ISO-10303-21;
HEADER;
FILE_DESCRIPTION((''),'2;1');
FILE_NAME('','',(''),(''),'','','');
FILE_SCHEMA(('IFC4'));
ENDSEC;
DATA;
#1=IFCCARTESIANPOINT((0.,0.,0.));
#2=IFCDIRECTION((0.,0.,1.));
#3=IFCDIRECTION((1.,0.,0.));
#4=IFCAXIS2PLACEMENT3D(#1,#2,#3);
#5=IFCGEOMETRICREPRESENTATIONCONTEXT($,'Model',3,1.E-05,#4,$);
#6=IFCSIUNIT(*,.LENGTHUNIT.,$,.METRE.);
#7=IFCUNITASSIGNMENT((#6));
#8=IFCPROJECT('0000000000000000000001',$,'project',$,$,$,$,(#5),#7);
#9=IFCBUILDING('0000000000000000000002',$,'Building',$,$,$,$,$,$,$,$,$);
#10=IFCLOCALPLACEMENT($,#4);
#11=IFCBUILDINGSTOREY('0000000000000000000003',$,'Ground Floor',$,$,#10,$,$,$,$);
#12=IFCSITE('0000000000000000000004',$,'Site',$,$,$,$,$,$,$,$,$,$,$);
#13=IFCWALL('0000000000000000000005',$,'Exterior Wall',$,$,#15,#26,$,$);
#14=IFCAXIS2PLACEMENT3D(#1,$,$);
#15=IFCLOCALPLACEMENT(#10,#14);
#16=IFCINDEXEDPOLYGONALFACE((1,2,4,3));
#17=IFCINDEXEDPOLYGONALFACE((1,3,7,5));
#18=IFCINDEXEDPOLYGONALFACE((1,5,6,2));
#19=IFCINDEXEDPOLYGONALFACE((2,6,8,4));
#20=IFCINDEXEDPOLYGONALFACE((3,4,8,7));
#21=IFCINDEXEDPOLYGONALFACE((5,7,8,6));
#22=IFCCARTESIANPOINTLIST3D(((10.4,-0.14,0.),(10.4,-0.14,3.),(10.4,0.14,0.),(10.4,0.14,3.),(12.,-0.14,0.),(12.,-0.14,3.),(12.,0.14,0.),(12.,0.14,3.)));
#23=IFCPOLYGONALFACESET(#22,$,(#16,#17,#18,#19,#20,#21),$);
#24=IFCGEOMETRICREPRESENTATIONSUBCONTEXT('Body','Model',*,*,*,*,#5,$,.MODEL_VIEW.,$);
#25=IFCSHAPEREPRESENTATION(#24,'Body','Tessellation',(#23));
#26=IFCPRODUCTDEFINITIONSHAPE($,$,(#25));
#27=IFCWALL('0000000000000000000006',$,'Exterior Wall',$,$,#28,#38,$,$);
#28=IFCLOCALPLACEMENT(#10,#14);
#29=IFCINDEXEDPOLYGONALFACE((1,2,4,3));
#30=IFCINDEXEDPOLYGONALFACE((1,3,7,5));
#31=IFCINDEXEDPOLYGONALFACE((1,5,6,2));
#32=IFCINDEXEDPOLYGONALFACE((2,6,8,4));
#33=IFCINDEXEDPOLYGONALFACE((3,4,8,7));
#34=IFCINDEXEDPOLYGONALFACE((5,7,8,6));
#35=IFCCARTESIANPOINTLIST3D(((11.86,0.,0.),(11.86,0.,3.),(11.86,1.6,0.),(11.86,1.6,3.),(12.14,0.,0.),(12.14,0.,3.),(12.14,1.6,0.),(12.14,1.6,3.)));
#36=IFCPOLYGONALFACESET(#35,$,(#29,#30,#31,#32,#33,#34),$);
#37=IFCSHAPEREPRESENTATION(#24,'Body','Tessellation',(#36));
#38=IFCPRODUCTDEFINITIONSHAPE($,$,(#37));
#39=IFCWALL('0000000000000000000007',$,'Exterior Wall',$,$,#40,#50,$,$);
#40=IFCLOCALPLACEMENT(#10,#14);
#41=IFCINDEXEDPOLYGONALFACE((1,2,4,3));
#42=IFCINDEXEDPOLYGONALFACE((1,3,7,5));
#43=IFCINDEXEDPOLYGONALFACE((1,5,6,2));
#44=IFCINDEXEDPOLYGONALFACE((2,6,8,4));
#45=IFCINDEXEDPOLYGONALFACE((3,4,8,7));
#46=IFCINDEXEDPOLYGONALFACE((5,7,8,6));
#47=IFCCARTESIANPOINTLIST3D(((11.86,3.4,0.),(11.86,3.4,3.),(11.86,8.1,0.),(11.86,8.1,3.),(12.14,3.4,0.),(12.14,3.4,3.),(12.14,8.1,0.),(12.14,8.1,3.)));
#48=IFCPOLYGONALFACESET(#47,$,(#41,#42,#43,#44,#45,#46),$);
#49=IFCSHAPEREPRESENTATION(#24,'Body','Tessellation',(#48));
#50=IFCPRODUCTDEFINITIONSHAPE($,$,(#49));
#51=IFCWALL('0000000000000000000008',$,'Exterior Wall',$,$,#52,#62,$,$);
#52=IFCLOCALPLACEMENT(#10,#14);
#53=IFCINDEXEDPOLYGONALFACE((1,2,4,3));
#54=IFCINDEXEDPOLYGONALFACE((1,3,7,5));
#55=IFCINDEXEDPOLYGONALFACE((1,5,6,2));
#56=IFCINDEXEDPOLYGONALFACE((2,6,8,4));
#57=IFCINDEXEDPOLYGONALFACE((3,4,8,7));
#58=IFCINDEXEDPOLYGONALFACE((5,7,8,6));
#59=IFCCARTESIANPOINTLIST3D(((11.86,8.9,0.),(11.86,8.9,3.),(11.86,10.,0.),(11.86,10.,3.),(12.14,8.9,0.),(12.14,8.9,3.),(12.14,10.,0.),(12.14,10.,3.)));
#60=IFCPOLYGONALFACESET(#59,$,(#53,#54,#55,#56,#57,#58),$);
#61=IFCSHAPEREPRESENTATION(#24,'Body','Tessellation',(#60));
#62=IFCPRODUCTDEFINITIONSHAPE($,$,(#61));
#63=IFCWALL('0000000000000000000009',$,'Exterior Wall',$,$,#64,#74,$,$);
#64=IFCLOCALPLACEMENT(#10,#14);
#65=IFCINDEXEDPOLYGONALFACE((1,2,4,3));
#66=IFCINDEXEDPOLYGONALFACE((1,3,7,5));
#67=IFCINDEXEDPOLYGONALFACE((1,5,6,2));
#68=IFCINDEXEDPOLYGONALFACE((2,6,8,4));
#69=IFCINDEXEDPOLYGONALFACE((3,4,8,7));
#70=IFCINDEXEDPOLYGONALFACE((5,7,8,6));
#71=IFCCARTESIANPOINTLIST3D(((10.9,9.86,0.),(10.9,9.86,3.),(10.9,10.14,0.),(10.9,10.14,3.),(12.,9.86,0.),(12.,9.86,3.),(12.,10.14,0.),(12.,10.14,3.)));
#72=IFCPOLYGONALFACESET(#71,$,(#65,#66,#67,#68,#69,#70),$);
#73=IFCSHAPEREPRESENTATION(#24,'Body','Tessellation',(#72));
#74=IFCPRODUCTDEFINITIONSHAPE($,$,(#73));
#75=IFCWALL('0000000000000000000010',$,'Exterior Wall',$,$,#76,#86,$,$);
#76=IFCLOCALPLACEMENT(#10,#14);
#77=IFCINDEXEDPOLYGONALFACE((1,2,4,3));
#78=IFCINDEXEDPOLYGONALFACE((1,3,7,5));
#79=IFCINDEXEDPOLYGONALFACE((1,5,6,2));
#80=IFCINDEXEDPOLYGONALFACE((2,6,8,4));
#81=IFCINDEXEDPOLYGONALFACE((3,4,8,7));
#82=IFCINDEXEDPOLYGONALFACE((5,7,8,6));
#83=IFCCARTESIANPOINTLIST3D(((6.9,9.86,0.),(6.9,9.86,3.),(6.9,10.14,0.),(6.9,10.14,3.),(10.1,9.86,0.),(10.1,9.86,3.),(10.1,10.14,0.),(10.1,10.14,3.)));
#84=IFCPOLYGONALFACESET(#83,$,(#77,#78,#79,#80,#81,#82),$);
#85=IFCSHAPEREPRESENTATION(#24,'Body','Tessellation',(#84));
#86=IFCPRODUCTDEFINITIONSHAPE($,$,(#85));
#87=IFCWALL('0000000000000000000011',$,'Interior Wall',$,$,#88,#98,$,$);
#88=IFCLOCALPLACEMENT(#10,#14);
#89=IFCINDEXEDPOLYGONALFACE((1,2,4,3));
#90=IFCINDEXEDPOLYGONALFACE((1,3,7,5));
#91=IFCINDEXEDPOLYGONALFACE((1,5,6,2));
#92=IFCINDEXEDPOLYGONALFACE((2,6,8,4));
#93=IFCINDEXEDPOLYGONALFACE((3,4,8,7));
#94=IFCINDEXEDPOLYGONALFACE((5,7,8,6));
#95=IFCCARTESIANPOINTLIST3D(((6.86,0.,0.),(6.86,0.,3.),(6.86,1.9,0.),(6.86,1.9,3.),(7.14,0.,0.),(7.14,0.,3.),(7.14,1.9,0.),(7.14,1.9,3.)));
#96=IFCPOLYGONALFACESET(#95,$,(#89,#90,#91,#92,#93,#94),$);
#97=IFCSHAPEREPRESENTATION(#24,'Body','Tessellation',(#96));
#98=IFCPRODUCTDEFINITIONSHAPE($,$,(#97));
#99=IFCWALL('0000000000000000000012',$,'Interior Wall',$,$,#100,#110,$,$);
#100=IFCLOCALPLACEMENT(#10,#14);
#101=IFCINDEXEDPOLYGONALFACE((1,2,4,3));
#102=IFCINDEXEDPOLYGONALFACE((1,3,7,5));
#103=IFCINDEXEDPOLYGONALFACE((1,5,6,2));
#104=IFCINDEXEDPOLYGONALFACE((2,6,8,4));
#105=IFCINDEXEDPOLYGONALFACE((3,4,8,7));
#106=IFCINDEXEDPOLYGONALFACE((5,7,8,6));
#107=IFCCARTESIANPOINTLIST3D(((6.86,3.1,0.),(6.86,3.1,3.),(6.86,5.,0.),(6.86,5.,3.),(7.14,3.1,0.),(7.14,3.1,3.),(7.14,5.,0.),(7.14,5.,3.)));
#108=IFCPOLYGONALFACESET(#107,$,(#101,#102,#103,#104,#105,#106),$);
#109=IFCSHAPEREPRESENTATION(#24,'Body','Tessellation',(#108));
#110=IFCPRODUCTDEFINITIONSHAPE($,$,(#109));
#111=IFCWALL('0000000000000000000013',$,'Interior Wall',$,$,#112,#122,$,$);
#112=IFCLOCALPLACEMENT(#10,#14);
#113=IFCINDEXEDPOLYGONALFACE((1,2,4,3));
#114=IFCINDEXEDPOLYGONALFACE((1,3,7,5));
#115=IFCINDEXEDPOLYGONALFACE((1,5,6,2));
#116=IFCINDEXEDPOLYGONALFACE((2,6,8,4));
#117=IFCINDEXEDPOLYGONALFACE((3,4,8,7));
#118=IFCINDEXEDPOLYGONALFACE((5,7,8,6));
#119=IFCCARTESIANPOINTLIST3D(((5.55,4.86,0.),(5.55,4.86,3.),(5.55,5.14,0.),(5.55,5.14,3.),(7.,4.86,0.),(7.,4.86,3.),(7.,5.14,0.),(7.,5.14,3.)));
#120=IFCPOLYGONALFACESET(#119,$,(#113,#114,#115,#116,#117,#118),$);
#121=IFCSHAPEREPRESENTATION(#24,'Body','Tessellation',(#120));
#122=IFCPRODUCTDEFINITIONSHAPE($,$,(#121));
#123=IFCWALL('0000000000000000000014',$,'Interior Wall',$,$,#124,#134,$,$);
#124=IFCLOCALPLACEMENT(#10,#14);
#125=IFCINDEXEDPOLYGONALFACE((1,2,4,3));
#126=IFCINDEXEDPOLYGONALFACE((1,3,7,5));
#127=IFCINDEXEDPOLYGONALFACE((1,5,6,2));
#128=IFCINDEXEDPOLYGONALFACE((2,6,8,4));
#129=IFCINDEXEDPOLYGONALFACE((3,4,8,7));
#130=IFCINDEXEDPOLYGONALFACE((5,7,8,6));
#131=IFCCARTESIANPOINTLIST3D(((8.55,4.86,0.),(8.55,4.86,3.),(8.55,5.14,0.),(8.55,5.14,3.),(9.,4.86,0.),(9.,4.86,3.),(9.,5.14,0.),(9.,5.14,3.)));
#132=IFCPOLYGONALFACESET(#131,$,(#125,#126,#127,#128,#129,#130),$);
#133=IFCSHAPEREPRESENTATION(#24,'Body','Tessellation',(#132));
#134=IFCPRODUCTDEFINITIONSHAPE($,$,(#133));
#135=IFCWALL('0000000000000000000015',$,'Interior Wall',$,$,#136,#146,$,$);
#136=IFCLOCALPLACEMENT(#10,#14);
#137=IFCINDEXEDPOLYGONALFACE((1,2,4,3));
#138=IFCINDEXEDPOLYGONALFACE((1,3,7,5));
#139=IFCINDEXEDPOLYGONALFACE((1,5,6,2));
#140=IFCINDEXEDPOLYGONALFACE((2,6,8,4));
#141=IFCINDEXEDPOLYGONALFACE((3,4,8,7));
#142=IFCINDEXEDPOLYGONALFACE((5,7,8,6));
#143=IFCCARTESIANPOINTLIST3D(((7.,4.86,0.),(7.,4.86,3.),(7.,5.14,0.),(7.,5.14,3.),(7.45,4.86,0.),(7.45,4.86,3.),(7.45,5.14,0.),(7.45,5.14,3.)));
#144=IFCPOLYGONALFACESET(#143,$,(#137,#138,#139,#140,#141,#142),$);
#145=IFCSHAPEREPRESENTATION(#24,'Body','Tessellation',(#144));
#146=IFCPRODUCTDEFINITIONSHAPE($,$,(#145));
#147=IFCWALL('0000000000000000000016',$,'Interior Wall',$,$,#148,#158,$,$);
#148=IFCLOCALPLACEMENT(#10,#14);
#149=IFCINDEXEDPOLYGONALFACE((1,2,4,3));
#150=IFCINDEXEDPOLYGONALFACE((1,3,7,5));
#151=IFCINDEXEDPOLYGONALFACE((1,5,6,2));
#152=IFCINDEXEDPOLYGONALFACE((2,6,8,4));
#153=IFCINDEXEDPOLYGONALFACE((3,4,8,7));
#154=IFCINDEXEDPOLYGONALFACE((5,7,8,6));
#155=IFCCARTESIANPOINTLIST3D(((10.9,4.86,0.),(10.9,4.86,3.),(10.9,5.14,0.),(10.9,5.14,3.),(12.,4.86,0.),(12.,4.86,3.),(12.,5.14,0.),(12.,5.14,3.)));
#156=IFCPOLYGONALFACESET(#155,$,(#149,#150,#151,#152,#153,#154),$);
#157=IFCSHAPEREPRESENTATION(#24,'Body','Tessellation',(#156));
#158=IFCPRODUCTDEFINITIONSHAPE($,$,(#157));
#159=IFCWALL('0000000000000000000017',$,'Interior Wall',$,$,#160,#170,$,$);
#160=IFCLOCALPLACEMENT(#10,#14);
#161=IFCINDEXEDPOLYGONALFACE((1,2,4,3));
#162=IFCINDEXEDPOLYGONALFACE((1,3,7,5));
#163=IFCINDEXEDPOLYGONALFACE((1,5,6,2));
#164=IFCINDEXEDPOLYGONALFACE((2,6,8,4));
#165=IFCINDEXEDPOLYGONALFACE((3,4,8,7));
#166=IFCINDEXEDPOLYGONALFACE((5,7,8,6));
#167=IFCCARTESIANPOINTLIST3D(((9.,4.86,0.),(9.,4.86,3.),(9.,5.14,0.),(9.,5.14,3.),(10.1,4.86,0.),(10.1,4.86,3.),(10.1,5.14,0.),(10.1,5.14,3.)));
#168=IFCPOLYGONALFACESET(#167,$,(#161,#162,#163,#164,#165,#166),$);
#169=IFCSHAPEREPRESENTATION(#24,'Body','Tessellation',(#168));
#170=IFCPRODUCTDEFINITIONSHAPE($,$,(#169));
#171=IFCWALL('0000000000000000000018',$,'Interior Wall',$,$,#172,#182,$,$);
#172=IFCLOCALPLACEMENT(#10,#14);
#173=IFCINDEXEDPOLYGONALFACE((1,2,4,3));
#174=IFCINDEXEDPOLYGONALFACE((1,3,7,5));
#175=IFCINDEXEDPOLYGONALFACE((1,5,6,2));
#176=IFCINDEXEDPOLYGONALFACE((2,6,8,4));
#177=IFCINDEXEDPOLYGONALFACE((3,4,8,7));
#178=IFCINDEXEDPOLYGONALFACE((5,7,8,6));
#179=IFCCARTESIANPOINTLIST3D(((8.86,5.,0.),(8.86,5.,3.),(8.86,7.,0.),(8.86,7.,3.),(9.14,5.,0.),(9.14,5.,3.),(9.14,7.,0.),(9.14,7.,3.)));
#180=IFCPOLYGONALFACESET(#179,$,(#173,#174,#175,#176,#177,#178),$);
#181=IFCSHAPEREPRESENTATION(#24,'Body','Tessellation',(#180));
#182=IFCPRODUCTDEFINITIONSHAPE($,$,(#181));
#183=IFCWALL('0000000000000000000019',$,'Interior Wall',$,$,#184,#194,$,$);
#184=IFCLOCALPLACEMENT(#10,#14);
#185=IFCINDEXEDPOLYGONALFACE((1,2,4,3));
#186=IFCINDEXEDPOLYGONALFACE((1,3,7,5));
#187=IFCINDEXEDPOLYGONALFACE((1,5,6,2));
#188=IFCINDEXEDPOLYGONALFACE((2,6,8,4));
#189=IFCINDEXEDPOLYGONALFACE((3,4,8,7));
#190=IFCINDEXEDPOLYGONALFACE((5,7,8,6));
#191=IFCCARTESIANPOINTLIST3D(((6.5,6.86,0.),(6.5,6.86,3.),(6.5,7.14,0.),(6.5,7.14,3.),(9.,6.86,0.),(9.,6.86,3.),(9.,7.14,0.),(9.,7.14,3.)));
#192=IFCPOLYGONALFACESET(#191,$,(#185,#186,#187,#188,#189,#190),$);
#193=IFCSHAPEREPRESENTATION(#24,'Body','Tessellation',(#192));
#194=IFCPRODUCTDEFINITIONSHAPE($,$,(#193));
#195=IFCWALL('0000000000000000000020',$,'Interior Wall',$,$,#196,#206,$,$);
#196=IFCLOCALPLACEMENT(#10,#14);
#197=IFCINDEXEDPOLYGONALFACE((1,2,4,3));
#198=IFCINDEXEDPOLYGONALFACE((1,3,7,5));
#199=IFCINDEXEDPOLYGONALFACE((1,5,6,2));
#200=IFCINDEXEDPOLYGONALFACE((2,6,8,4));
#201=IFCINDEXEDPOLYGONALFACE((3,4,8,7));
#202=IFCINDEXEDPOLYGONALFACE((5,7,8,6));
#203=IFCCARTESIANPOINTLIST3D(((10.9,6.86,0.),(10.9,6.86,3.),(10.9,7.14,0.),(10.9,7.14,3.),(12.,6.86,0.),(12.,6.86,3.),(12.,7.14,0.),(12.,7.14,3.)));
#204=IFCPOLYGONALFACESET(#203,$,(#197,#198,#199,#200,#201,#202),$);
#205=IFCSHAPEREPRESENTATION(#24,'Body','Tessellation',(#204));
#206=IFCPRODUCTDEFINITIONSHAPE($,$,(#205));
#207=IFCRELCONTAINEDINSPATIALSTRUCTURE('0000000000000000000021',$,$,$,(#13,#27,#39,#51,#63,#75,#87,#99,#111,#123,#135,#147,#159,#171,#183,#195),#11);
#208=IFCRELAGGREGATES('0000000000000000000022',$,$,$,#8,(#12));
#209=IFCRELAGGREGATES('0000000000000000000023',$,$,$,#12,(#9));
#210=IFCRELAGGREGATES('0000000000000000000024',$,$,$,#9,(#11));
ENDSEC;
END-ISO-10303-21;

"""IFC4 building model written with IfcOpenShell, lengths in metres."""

from ifc_helpers import new_model, si_unit, frame, origin_with_axes, place, context, subcontext, project, spatial, indexed_curve, outline, extrude, element, save


model = new_model("IFC4")

# Units and contexts
model_context = context("Model", 3, precision=1e-05, world=origin_with_axes())
body_context = subcontext(model_context, "Body", "Model", "MODEL_VIEW")
ifc_project = project(units=[si_unit("LENGTHUNIT", "METRE")], contexts=[model_context])

# Site, building, storey
site = spatial("IfcSite", under=ifc_project, Name="Site")
building = spatial("IfcBuilding", under=site, Name="Building")
storey_placement = place(None, origin_with_axes())
storey = spatial("IfcBuildingStorey", under=building, at=storey_placement, Name="Ground Floor")

# Walls
wall_1_placement = place(storey_placement, frame((10.4, 0.0, 0.0), z_axis=(0.0, 0.0, 1.0), x_axis=(1.0, 0.0, 0.0)))
element("IfcWall", 1, at=wall_1_placement, inside=storey, Name="Exterior Wall", context=body_context, shape_type="SweptSolid", body=[
    extrude(outline(indexed_curve([(0.0, 0.0), (0.0, 0.28), (1.6, 0.28), (1.6, 0.0), (0.0, 0.0)], self_intersect=False)), frame((0.0, -0.14, 0.0), z_axis=(0.0, 0.0, 1.0), x_axis=(1.0, 0.0, 0.0)), (0.0, 0.0, 1.0), 3.0),
])
wall_2_placement = place(storey_placement, frame((12.0, 0.0, 0.0), z_axis=(0.0, 0.0, 1.0), x_axis=(0.0, 1.0, 0.0)))
element("IfcWall", 2, at=wall_2_placement, inside=storey, Name="Exterior Wall", context=body_context, shape_type="SweptSolid", body=[
    extrude(outline(indexed_curve([(0.0, 0.0), (0.0, 0.28), (1.6, 0.28), (1.6, 0.0), (0.0, 0.0)], self_intersect=False)), frame((0.0, -0.14, 0.0), z_axis=(0.0, 0.0, 1.0), x_axis=(1.0, 0.0, 0.0)), (0.0, 0.0, 1.0), 3.0),
])
wall_3_placement = place(storey_placement, frame((12.0, 3.4, 0.0), z_axis=(0.0, 0.0, 1.0), x_axis=(0.0, 1.0, 0.0)))
element("IfcWall", 3, at=wall_3_placement, inside=storey, Name="Exterior Wall", context=body_context, shape_type="SweptSolid", body=[
    extrude(outline(indexed_curve([(0.0, 0.0), (0.0, 0.28), (4.7, 0.28), (4.7, 0.0), (0.0, 0.0)], self_intersect=False)), frame((0.0, -0.14, 0.0), z_axis=(0.0, 0.0, 1.0), x_axis=(1.0, 0.0, 0.0)), (0.0, 0.0, 1.0), 3.0),
])
for number, where, z_axis, x_axis, name in (
    (4, (12.0, 8.9, 0.0), (0.0, 0.0, 1.0), (0.0, 1.0, 0.0), "Exterior Wall"),
    (5, (12.0, 10.0, 0.0), (0.0, 0.0, 1.0), (-1.0, 0.0, 0.0), "Exterior Wall"),
):
    element("IfcWall", number, at=place(storey_placement, frame(where, z_axis=z_axis, x_axis=x_axis)), inside=storey, Name=name, context=body_context, shape_type="SweptSolid", body=[
        extrude(outline(indexed_curve([(0.0, 0.0), (0.0, 0.28), (1.1, 0.28), (1.1, 0.0), (0.0, 0.0)], self_intersect=False)), frame((0.0, -0.14, 0.0), z_axis=(0.0, 0.0, 1.0), x_axis=(1.0, 0.0, 0.0)), (0.0, 0.0, 1.0), 3.0),
    ])
wall_4_placement = place(storey_placement, frame((10.1, 10.0, 0.0), z_axis=(0.0, 0.0, 1.0), x_axis=(-1.0, 0.0, 0.0)))
element("IfcWall", 6, at=wall_4_placement, inside=storey, Name="Exterior Wall", context=body_context, shape_type="SweptSolid", body=[
    extrude(outline(indexed_curve([(0.0, 0.0), (0.0, 0.28), (3.2, 0.28), (3.2, 0.0), (0.0, 0.0)], self_intersect=False)), frame((0.0, -0.14, 0.0), z_axis=(0.0, 0.0, 1.0), x_axis=(1.0, 0.0, 0.0)), (0.0, 0.0, 1.0), 3.0),
])
for number, where, z_axis, x_axis, name in (
    (7, (7.0, 0.0, 0.0), (0.0, 0.0, 1.0), (0.0, 1.0, 0.0), "Interior Wall"),
    (8, (7.0, 3.1, 0.0), (0.0, 0.0, 1.0), (0.0, 1.0, 0.0), "Interior Wall"),
):
    element("IfcWall", number, at=place(storey_placement, frame(where, z_axis=z_axis, x_axis=x_axis)), inside=storey, Name=name, context=body_context, shape_type="SweptSolid", body=[
        extrude(outline(indexed_curve([(0.0, 0.0), (0.0, 0.28), (1.9, 0.28), (1.9, 0.0), (0.0, 0.0)], self_intersect=False)), frame((0.0, -0.14, 0.0), z_axis=(0.0, 0.0, 1.0), x_axis=(1.0, 0.0, 0.0)), (0.0, 0.0, 1.0), 3.0),
    ])
wall_5_placement = place(storey_placement, frame((7.0, 5.0, 0.0), z_axis=(0.0, 0.0, 1.0), x_axis=(-1.0, 0.0, 0.0)))
element("IfcWall", 9, at=wall_5_placement, inside=storey, Name="Interior Wall", context=body_context, shape_type="SweptSolid", body=[
    extrude(outline(indexed_curve([(0.0, 0.0), (0.0, 0.28), (1.45, 0.28), (1.45, 0.0), (0.0, 0.0)], self_intersect=False)), frame((0.0, -0.14, 0.0), z_axis=(0.0, 0.0, 1.0), x_axis=(1.0, 0.0, 0.0)), (0.0, 0.0, 1.0), 3.0),
])
wall_6_placement = place(storey_placement, frame((9.0, 5.0, 0.0), z_axis=(0.0, 0.0, 1.0), x_axis=(-1.0, 0.0, 0.0)))
element("IfcWall", 10, at=wall_6_placement, inside=storey, Name="Interior Wall", context=body_context, shape_type="SweptSolid", body=[
    extrude(outline(indexed_curve([(0.0, 0.0), (0.0, 0.28), (0.45, 0.28), (0.45, 0.0), (0.0, 0.0)], self_intersect=False)), frame((0.0, -0.14, 0.0), z_axis=(0.0, 0.0, 1.0), x_axis=(1.0, 0.0, 0.0)), (0.0, 0.0, 1.0), 3.0),
])
wall_7_placement = place(storey_placement, frame((7.45, 5.0, 0.0), z_axis=(0.0, 0.0, 1.0), x_axis=(-1.0, 0.0, 0.0)))
element("IfcWall", 11, at=wall_7_placement, inside=storey, Name="Interior Wall", context=body_context, shape_type="SweptSolid", body=[
    extrude(outline(indexed_curve([(0.0, 0.0), (0.0, 0.28), (0.45, 0.28), (0.45, 0.0), (0.0, 0.0)], self_intersect=False)), frame((0.0, -0.14, 0.0), z_axis=(0.0, 0.0, 1.0), x_axis=(1.0, 0.0, 0.0)), (0.0, 0.0, 1.0), 3.0),
])
for number, where, z_axis, x_axis, name in (
    (12, (12.0, 5.0, 0.0), (0.0, 0.0, 1.0), (-1.0, 0.0, 0.0), "Interior Wall"),
    (13, (10.1, 5.0, 0.0), (0.0, 0.0, 1.0), (-1.0, 0.0, 0.0), "Interior Wall"),
):
    element("IfcWall", number, at=place(storey_placement, frame(where, z_axis=z_axis, x_axis=x_axis)), inside=storey, Name=name, context=body_context, shape_type="SweptSolid", body=[
        extrude(outline(indexed_curve([(0.0, 0.0), (0.0, 0.28), (1.1, 0.28), (1.1, 0.0), (0.0, 0.0)], self_intersect=False)), frame((0.0, -0.14, 0.0), z_axis=(0.0, 0.0, 1.0), x_axis=(1.0, 0.0, 0.0)), (0.0, 0.0, 1.0), 3.0),
    ])
wall_8_placement = place(storey_placement, frame((9.0, 5.0, 0.0), z_axis=(0.0, 0.0, 1.0), x_axis=(0.0, 1.0, 0.0)))
element("IfcWall", 14, at=wall_8_placement, inside=storey, Name="Interior Wall", context=body_context, shape_type="SweptSolid", body=[
    extrude(outline(indexed_curve([(0.0, 0.0), (0.0, 0.28), (2.0, 0.28), (2.0, 0.0), (0.0, 0.0)], self_intersect=False)), frame((0.0, -0.14, 0.0), z_axis=(0.0, 0.0, 1.0), x_axis=(1.0, 0.0, 0.0)), (0.0, 0.0, 1.0), 3.0),
])
wall_9_placement = place(storey_placement, frame((9.0, 7.0, 0.0), z_axis=(0.0, 0.0, 1.0), x_axis=(-1.0, 0.0, 0.0)))
element("IfcWall", 15, at=wall_9_placement, inside=storey, Name="Interior Wall", context=body_context, shape_type="SweptSolid", body=[
    extrude(outline(indexed_curve([(0.0, 0.0), (0.0, 0.28), (2.5, 0.28), (2.5, 0.0), (0.0, 0.0)], self_intersect=False)), frame((0.0, -0.14, 0.0), z_axis=(0.0, 0.0, 1.0), x_axis=(1.0, 0.0, 0.0)), (0.0, 0.0, 1.0), 3.0),
])
for number, where, z_axis, x_axis, name in (
    (16, (12.0, 7.0, 0.0), (0.0, 0.0, 1.0), (-1.0, 0.0, 0.0), "Interior Wall"),
):
    element("IfcWall", number, at=place(storey_placement, frame(where, z_axis=z_axis, x_axis=x_axis)), inside=storey, Name=name, context=body_context, shape_type="SweptSolid", body=[
        extrude(outline(indexed_curve([(0.0, 0.0), (0.0, 0.28), (1.1, 0.28), (1.1, 0.0), (0.0, 0.0)], self_intersect=False)), frame((0.0, -0.14, 0.0), z_axis=(0.0, 0.0, 1.0), x_axis=(1.0, 0.0, 0.0)), (0.0, 0.0, 1.0), 3.0),
    ])

save(model, "model.ifc")
